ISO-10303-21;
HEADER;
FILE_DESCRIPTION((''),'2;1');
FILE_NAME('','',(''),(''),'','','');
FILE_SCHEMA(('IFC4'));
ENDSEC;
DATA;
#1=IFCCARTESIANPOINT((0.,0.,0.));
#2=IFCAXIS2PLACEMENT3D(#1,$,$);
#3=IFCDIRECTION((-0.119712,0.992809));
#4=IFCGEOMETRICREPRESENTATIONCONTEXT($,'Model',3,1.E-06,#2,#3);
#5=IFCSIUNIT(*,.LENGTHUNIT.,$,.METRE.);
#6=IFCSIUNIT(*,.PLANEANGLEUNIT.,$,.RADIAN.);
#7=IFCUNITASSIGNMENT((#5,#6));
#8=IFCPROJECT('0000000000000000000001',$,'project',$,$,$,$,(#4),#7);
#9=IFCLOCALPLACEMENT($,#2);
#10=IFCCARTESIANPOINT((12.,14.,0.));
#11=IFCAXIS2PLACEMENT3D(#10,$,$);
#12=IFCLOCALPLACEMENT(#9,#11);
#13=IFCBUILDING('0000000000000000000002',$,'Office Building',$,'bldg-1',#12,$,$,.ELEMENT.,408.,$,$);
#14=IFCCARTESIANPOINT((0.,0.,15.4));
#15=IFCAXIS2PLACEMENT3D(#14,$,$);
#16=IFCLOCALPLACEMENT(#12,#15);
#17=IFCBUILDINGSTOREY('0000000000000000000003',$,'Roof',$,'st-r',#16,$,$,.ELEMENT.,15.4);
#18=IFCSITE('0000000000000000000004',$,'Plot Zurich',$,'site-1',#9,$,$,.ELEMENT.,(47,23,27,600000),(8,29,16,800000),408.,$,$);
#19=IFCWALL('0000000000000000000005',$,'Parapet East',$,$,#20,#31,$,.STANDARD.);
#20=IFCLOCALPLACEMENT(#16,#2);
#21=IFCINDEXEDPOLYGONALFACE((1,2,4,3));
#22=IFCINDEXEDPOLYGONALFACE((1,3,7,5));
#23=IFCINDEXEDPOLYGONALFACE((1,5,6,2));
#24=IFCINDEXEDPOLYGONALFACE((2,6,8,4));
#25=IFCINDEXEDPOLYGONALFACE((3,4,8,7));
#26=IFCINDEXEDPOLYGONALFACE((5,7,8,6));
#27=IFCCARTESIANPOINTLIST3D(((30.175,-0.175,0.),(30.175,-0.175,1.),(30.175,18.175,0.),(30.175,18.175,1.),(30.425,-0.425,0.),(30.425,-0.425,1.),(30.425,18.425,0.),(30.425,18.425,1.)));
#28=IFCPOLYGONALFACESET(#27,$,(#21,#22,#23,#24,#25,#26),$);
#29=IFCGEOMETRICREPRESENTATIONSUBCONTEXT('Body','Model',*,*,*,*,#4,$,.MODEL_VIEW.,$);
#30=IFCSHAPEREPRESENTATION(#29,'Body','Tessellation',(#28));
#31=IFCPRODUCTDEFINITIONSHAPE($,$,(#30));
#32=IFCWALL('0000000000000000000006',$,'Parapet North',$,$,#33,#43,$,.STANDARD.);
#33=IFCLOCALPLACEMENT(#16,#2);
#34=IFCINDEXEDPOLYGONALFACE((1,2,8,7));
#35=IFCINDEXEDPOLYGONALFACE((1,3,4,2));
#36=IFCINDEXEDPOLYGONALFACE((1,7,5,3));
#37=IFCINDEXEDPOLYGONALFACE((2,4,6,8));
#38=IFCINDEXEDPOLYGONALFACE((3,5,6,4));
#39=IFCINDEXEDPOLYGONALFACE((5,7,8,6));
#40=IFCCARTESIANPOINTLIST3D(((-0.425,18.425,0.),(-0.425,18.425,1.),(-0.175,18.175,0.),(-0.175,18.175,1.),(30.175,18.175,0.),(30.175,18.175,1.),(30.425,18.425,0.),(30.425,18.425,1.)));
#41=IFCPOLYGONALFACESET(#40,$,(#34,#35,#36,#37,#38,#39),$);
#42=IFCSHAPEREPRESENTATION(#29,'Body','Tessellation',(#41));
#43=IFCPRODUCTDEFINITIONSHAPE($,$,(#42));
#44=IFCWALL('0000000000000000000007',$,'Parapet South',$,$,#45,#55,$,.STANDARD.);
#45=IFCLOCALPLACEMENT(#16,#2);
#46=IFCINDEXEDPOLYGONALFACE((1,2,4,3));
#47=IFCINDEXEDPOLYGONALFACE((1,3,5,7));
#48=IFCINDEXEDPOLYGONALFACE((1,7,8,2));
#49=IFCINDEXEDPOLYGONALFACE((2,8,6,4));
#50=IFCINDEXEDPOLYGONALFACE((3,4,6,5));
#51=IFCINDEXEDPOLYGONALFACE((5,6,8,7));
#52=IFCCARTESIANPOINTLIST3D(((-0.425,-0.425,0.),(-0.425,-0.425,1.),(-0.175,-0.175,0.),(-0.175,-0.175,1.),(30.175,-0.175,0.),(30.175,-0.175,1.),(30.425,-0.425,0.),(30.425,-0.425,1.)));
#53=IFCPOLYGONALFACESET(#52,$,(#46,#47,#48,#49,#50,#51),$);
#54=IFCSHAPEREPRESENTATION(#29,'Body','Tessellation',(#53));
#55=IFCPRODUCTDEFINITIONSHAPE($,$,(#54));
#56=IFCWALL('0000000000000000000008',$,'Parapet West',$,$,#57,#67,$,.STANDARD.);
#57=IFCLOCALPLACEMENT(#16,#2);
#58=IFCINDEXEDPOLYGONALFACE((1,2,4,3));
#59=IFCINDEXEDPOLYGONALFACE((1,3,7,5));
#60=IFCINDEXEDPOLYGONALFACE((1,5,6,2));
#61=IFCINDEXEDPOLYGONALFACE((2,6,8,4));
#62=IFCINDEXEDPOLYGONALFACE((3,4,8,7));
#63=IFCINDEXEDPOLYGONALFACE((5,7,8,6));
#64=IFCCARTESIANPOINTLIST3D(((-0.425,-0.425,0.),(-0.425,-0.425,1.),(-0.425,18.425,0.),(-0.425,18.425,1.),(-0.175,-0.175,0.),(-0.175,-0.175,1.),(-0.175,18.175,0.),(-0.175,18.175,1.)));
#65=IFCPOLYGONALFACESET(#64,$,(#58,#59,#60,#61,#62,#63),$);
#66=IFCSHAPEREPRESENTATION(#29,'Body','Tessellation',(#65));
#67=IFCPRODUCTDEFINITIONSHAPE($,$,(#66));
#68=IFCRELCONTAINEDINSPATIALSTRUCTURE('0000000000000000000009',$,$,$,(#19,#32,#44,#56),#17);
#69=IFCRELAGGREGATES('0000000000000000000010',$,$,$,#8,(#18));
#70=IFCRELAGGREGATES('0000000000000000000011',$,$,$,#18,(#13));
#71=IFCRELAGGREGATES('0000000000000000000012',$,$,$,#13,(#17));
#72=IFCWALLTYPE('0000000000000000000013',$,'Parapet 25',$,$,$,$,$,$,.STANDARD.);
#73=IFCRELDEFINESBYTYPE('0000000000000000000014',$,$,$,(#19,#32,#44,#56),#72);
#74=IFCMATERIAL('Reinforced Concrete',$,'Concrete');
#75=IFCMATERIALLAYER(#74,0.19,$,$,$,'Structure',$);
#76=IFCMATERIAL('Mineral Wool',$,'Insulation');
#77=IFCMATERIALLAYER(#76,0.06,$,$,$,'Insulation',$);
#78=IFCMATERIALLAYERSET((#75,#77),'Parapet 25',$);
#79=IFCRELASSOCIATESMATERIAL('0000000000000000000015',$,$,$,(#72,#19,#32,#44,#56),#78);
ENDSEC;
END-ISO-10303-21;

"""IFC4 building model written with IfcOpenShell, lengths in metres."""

from ifc_helpers import new_model, si_unit, direction, frame, origin, place, context, subcontext, project, spatial, polyline, outline, extrude, material, layer, layer_set, layer_usage, type_object, element, save


model = new_model("IFC4")

# Units and contexts
model_context = context("Model", 3, precision=1e-06, world=origin(), true_north=direction((-0.119712, 0.992809)))
body_context = subcontext(model_context, "Body", "Model", "MODEL_VIEW")
ifc_project = project(units=[si_unit("LENGTHUNIT", "METRE"), si_unit("PLANEANGLEUNIT", "RADIAN")], contexts=[model_context])

# Site, building, storey
site_placement = place(None, origin())
site = spatial("IfcSite", under=ifc_project, at=site_placement, Name="Plot Zurich", ObjectType="site-1", CompositionType="ELEMENT", RefLatitude=(47, 23, 27, 600000), RefLongitude=(8, 29, 16, 800000), RefElevation=408.0)
building_placement = place(site_placement, frame((12.0, 14.0, 0.0)))
building = spatial("IfcBuilding", under=site, at=building_placement, Name="Office Building", ObjectType="bldg-1", CompositionType="ELEMENT", ElevationOfRefHeight=408.0)
storey_placement = place(building_placement, frame((0.0, 0.0, 15.4)))
storey = spatial("IfcBuildingStorey", under=building, at=storey_placement, Name="Roof", ObjectType="st-r", CompositionType="ELEMENT", Elevation=15.4)

# Walls
ifc_material_1 = material(Name="Reinforced Concrete", Category="Concrete")
ifc_layer_1 = layer(ifc_material_1, 0.19, Category="Structure")
ifc_material_2 = material(Name="Mineral Wool", Category="Insulation")
ifc_layer_2 = layer(ifc_material_2, 0.06, Category="Insulation")
ifc_layer_set = layer_set([ifc_layer_1, ifc_layer_2], Name="Parapet 25")
ifc_layer_usage_1 = layer_usage(ifc_layer_set, "AXIS2", "NEGATIVE", 0.125)
wall_type = type_object("IfcWallType", Name="Parapet 25", PredefinedType="STANDARD", material=ifc_layer_set)
wall_1_placement = place(storey_placement, origin())
element("IfcWall", 1, at=wall_1_placement, inside=storey, type_object=wall_type, material=ifc_layer_usage_1, Name="Parapet East", PredefinedType="STANDARD", context=body_context, shape_type="SweptSolid", body=[
    extrude(outline(polyline([(30.425, -0.425), (30.425, 18.425), (30.175, 18.175), (30.175, -0.175), (30.425, -0.425)])), origin(), (0.0, 0.0, 1.0), 1.0),
])
ifc_layer_usage_2 = layer_usage(ifc_layer_set, "AXIS2", "NEGATIVE", 0.125)
wall_2_placement = place(storey_placement, origin())
element("IfcWall", 2, at=wall_2_placement, inside=storey, type_object=wall_type, material=ifc_layer_usage_2, Name="Parapet North", PredefinedType="STANDARD", context=body_context, shape_type="SweptSolid", body=[
    extrude(outline(polyline([(30.425, 18.425), (-0.425, 18.425), (-0.175, 18.175), (30.175, 18.175), (30.425, 18.425)])), origin(), (0.0, 0.0, 1.0), 1.0),
])
ifc_layer_usage_3 = layer_usage(ifc_layer_set, "AXIS2", "NEGATIVE", 0.125)
wall_3_placement = place(storey_placement, origin())
element("IfcWall", 3, at=wall_3_placement, inside=storey, type_object=wall_type, material=ifc_layer_usage_3, Name="Parapet South", PredefinedType="STANDARD", context=body_context, shape_type="SweptSolid", body=[
    extrude(outline(polyline([(-0.425, -0.425), (30.425, -0.425), (30.175, -0.175), (-0.175, -0.175), (-0.425, -0.425)])), origin(), (0.0, 0.0, 1.0), 1.0),
])
ifc_layer_usage_4 = layer_usage(ifc_layer_set, "AXIS2", "NEGATIVE", 0.125)
wall_4_placement = place(storey_placement, origin())
element("IfcWall", 4, at=wall_4_placement, inside=storey, type_object=wall_type, material=ifc_layer_usage_4, Name="Parapet West", PredefinedType="STANDARD", context=body_context, shape_type="SweptSolid", body=[
    extrude(outline(polyline([(-0.425, 18.425), (-0.425, -0.425), (-0.175, -0.175), (-0.175, 18.175), (-0.425, 18.425)])), origin(), (0.0, 0.0, 1.0), 1.0),
])

save(model, "model.ifc")
